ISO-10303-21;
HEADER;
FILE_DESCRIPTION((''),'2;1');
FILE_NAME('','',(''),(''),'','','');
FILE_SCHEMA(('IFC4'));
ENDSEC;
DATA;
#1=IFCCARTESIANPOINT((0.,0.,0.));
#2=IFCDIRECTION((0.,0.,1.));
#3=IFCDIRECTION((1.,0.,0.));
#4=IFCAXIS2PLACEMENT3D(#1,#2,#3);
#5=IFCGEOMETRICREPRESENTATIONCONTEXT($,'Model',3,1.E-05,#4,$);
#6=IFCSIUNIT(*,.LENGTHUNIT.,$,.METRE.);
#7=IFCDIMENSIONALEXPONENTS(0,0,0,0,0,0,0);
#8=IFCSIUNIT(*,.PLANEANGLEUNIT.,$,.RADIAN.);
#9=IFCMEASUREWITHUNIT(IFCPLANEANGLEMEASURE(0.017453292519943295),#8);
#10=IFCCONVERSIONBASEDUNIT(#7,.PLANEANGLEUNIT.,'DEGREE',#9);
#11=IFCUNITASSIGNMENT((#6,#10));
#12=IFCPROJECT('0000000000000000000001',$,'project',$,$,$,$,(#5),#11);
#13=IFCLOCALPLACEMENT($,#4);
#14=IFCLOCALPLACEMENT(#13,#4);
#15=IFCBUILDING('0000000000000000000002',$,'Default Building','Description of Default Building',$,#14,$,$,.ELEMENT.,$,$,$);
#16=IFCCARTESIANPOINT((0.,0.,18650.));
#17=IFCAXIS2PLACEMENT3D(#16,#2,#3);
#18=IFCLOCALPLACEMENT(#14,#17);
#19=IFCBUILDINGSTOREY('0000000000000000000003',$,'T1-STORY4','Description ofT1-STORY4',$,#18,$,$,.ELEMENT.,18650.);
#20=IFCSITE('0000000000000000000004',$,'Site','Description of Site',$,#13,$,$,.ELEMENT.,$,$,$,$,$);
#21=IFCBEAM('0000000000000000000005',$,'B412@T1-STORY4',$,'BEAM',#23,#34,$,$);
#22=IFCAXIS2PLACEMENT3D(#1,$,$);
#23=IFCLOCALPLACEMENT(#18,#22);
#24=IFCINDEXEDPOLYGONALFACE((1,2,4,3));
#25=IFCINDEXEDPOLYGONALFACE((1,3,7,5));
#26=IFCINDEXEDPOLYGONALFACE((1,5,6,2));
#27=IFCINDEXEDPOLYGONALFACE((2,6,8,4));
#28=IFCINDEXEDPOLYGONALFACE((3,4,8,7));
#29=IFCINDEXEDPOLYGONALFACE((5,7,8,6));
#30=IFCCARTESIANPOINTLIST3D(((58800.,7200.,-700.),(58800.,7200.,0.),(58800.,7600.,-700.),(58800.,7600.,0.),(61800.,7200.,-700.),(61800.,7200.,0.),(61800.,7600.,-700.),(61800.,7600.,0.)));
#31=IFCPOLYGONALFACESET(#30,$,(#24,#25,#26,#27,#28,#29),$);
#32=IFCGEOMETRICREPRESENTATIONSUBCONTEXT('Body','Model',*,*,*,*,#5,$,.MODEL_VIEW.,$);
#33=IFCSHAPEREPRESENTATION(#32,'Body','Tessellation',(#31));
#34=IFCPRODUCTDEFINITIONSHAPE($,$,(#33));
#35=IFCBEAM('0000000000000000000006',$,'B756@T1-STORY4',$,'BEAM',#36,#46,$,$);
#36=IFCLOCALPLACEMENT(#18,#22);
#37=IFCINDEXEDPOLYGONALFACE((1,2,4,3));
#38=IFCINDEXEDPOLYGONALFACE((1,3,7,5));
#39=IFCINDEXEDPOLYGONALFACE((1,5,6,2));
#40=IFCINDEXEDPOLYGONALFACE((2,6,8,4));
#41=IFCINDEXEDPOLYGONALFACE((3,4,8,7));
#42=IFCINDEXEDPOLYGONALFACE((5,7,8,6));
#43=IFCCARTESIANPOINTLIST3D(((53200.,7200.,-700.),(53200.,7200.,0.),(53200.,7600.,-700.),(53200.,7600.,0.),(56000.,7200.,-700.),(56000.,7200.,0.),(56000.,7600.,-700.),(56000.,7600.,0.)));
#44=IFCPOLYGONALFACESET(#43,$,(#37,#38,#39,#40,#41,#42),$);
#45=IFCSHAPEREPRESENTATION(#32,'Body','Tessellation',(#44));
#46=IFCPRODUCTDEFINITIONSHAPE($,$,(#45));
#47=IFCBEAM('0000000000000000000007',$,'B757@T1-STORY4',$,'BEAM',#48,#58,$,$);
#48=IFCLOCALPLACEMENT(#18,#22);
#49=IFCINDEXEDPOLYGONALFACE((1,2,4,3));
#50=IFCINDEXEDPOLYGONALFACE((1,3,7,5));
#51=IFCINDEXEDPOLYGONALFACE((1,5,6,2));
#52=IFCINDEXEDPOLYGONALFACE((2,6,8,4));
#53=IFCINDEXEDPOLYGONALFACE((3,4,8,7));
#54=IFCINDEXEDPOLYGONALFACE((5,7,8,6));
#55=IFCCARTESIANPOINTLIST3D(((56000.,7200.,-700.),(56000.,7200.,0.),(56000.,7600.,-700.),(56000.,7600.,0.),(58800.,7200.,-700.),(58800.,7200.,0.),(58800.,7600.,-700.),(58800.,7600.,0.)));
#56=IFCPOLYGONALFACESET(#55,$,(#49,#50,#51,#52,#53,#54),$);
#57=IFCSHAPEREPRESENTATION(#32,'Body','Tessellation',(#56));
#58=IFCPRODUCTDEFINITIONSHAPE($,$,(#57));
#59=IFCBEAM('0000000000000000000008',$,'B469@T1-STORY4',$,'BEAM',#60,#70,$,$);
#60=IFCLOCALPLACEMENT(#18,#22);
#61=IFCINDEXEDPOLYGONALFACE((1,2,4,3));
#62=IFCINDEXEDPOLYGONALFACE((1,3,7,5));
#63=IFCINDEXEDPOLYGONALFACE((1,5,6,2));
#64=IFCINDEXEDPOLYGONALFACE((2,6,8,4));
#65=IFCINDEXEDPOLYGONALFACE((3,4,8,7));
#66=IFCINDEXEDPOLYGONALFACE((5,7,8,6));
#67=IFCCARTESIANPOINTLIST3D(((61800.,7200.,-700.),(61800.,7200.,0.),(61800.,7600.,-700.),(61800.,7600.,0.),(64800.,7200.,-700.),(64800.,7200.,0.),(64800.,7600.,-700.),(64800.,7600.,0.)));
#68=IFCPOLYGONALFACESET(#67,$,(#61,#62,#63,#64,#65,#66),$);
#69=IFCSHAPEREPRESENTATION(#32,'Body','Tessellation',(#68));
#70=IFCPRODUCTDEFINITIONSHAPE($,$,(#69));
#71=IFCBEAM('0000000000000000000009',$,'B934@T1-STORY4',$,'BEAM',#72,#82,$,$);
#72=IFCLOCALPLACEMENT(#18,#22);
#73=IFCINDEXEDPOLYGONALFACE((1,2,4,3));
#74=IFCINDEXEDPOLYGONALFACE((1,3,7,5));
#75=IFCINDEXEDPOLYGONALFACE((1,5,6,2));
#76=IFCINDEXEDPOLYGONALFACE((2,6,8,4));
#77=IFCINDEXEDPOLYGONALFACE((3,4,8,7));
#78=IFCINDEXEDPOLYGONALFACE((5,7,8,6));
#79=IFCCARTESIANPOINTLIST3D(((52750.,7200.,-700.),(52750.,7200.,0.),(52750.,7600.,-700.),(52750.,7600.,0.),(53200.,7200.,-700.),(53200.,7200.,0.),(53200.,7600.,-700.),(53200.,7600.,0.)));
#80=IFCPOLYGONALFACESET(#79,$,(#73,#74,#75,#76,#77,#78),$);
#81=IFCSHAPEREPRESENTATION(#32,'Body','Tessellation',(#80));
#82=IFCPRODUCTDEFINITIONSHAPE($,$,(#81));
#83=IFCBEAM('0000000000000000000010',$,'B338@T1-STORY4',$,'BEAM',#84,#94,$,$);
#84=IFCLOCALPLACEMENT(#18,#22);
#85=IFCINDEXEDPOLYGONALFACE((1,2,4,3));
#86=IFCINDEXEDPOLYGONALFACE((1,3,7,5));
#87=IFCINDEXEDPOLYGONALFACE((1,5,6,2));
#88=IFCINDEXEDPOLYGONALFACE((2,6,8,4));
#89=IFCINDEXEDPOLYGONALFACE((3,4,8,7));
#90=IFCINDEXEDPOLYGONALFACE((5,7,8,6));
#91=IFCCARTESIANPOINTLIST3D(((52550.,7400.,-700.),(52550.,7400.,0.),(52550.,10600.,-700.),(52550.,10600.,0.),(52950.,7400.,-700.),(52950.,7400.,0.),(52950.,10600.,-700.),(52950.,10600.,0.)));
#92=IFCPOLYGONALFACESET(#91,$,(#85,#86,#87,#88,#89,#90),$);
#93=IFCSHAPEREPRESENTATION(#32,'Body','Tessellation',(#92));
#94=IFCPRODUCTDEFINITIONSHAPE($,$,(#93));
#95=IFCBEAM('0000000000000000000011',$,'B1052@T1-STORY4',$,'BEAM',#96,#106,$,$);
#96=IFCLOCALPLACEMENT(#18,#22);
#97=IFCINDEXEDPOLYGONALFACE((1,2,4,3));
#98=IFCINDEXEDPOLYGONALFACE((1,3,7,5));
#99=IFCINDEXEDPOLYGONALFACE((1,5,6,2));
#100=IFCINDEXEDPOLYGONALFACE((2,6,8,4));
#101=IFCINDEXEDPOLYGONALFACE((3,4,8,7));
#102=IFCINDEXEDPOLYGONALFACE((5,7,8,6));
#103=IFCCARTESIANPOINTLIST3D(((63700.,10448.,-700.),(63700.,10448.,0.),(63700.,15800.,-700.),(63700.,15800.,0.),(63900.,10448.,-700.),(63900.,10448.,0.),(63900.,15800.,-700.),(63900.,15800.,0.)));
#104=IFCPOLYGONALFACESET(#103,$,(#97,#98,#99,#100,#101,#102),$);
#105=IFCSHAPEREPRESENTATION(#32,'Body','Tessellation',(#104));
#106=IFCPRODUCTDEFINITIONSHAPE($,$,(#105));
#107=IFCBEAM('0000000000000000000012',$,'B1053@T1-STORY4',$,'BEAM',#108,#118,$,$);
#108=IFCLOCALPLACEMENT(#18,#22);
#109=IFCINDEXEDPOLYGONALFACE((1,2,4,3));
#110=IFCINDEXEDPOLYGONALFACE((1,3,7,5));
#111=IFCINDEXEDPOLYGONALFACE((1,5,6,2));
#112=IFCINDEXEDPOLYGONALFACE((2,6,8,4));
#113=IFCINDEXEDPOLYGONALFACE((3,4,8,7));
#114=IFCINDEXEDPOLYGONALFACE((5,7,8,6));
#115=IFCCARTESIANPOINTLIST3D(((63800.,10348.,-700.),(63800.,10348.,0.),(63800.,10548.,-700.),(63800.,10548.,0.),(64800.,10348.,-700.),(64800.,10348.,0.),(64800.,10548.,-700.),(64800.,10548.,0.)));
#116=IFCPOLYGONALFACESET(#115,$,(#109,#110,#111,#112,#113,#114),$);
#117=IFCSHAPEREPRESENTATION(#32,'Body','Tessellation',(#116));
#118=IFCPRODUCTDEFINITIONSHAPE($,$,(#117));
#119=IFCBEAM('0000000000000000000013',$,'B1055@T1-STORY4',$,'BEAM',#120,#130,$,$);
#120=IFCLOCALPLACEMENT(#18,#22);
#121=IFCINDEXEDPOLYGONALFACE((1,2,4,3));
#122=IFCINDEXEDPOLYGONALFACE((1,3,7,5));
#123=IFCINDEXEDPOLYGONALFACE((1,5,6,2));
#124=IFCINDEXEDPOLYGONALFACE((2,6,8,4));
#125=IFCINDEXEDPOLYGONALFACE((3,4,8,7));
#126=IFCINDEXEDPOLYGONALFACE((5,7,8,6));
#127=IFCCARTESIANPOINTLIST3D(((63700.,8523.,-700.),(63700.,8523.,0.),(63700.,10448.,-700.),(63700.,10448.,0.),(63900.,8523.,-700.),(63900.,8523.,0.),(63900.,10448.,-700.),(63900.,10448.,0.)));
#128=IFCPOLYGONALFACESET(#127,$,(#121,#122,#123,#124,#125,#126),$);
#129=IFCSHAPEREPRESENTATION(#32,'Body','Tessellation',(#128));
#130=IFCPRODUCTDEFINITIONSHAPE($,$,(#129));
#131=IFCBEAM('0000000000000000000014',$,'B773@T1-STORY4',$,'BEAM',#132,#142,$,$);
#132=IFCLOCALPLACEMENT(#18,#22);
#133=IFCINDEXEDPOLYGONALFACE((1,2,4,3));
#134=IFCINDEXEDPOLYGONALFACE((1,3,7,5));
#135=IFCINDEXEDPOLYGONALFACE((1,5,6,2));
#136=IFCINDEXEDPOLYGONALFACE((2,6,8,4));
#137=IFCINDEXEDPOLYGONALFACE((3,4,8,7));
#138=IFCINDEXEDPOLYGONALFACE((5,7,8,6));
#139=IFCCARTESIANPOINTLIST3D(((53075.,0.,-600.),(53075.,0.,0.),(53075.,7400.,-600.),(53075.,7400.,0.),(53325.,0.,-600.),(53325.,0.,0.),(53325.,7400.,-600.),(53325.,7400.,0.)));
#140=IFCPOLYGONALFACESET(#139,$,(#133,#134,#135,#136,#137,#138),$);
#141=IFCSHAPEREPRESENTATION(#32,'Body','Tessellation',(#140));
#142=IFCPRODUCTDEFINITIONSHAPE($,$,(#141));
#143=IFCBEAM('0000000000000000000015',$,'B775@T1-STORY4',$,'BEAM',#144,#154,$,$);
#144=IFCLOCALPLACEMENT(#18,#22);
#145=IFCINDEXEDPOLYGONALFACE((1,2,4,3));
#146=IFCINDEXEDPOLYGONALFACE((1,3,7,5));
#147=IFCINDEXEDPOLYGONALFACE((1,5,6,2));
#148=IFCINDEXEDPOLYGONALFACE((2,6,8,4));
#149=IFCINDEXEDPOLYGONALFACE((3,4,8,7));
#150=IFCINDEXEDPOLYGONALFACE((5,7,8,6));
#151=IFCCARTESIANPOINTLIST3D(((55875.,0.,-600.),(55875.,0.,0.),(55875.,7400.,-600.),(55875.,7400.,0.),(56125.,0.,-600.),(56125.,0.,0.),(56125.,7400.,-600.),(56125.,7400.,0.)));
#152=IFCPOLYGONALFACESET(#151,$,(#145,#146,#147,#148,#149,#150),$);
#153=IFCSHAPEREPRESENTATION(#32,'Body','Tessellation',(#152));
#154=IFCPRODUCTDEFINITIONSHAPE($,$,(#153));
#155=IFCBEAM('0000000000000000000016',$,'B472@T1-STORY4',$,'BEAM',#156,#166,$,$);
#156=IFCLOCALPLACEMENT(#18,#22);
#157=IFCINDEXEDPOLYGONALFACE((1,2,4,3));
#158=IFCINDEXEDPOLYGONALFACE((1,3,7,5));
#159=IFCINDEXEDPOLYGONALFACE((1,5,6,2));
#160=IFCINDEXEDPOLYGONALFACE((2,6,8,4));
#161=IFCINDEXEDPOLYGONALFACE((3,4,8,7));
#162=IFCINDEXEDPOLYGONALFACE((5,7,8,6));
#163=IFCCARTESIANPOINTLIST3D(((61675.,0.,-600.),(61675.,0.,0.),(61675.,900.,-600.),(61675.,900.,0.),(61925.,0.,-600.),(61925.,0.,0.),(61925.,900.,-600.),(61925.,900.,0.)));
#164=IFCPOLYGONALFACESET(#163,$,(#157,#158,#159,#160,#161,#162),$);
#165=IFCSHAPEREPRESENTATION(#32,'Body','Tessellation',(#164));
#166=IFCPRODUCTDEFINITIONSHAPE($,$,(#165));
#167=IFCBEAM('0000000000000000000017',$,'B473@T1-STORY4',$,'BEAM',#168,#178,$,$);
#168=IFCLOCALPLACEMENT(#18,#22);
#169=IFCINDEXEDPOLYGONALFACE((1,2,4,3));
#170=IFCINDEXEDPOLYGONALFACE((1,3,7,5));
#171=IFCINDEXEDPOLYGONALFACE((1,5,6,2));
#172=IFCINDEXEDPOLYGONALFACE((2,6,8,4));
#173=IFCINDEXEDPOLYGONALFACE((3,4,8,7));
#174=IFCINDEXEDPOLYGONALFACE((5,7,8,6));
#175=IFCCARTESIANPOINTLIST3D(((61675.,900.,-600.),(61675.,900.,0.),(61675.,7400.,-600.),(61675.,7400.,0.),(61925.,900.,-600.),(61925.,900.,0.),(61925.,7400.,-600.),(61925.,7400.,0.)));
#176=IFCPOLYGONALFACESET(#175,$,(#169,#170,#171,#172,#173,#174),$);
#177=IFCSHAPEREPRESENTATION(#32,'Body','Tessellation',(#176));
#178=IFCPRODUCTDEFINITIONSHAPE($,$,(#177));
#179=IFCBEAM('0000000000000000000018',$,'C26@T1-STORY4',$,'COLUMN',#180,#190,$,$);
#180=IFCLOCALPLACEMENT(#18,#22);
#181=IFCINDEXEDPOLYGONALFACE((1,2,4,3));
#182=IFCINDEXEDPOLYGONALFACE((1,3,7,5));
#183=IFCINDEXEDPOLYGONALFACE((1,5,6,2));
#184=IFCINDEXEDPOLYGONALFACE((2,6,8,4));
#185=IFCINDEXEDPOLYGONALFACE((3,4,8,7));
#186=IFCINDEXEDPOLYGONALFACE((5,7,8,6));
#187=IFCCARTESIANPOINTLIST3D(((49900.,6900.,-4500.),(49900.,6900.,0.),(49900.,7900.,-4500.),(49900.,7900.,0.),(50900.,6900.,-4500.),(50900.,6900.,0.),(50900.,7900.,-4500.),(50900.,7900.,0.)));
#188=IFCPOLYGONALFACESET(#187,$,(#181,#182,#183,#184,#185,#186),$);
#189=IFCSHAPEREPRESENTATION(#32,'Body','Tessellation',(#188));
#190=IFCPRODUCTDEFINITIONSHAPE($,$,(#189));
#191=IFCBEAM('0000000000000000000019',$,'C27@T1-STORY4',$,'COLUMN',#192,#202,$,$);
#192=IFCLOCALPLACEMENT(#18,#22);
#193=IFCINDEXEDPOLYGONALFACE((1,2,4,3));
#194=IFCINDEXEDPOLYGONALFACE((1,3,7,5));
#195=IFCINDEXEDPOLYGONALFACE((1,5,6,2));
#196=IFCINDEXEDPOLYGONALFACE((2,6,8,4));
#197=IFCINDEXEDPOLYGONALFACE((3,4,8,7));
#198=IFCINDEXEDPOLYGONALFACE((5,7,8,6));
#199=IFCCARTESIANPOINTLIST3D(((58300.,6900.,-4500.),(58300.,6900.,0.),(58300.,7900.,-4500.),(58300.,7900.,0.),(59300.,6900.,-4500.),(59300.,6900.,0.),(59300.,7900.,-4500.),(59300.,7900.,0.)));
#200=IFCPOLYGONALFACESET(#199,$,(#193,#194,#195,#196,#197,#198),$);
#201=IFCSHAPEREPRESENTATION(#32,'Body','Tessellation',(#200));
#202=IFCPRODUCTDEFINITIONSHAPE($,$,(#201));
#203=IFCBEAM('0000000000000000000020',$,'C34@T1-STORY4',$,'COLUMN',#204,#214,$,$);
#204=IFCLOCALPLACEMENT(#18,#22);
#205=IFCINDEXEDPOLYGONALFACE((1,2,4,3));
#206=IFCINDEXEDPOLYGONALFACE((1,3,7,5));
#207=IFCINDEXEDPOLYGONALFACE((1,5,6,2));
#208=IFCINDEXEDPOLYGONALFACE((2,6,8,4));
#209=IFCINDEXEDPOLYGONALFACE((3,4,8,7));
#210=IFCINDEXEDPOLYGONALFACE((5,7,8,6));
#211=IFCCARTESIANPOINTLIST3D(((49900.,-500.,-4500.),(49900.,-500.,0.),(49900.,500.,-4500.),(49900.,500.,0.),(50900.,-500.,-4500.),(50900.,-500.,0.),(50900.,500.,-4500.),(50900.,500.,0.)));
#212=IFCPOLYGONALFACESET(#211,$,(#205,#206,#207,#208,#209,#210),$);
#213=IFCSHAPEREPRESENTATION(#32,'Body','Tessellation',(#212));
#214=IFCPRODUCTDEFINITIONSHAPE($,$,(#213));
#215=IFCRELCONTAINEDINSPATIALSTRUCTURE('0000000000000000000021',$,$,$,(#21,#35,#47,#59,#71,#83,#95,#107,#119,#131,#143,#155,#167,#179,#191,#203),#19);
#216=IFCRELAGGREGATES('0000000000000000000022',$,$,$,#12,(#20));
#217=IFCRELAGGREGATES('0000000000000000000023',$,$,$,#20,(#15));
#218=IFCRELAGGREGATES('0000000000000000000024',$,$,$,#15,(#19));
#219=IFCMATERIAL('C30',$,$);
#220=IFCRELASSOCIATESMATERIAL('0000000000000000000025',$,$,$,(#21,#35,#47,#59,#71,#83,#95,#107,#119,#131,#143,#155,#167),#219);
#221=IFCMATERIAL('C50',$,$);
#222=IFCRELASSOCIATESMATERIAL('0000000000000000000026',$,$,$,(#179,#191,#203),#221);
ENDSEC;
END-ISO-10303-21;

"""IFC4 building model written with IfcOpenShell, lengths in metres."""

from ifc_helpers import new_model, entity, si_unit, converted_unit, frame, origin_with_axes, place, context, subcontext, project, spatial, rectangle, extrude, material, element, save


model = new_model("IFC4")

# Units and contexts
model_context = context("Model", 3, precision=1e-05, world=origin_with_axes())
body_context = subcontext(model_context, "Body", "Model", "MODEL_VIEW")
ifc_project = project(units=[si_unit("LENGTHUNIT", "METRE"), converted_unit("PLANEANGLEUNIT", "DEGREE", entity("IfcPlaneAngleMeasure", 0.017453292519943295), si_unit("PLANEANGLEUNIT", "RADIAN"), dimensions=[0, 0, 0, 0, 0, 0, 0])], contexts=[model_context])

# Site, building, storey
site_placement = place(None, origin_with_axes())
site = spatial("IfcSite", under=ifc_project, at=site_placement, Name="Site", Description="Description of Site", CompositionType="ELEMENT")
building_placement = place(site_placement, origin_with_axes())
building = spatial("IfcBuilding", under=site, at=building_placement, Name="Default Building", Description="Description of Default Building", CompositionType="ELEMENT")
storey_placement = place(building_placement, frame((0.0, 0.0, 18650.0), z_axis=(0.0, 0.0, 1.0), x_axis=(1.0, 0.0, 0.0)))
storey = spatial("IfcBuildingStorey", under=building, at=storey_placement, Name="T1-STORY4", Description="Description ofT1-STORY4", CompositionType="ELEMENT", Elevation=18650.0)

# Beams
ifc_material_1 = material(Name="C30")
beam_1_placement = place(storey_placement, frame((58800.0, 7400.0, -350.0), z_axis=(1.0, 0.0, 0.0), x_axis=(0.0, 1.0, 0.0)))
element("IfcBeam", 1, at=beam_1_placement, inside=storey, material=ifc_material_1, Name="B412@T1-STORY4", ObjectType="BEAM", context=body_context, shape_type="SweptSolid", body=[
    extrude(rectangle(XDim=400.0, YDim=700.0), origin_with_axes(), (0.0, 0.0, 1.0), 3000.0),
])
for number, where, z_axis, x_axis, name in (
    (2, (53200.0, 7400.0, -350.0), (1.0, 0.0, 0.0), (0.0, 1.0, 0.0), "B756@T1-STORY4"),
    (3, (56000.0, 7400.0, -350.0), (1.0, 0.0, 0.0), (0.0, 1.0, 0.0), "B757@T1-STORY4"),
):
    element("IfcBeam", number, at=place(storey_placement, frame(where, z_axis=z_axis, x_axis=x_axis)), inside=storey, material=ifc_material_1, Name=name, ObjectType="BEAM", context=body_context, shape_type="SweptSolid", body=[
        extrude(rectangle(XDim=400.0, YDim=700.0), origin_with_axes(), (0.0, 0.0, 1.0), 2800.0),
    ])
beam_2_placement = place(storey_placement, frame((61800.0, 7400.0, -350.0), z_axis=(1.0, 0.0, 0.0), x_axis=(0.0, 1.0, 0.0)))
element("IfcBeam", 4, at=beam_2_placement, inside=storey, material=ifc_material_1, Name="B469@T1-STORY4", ObjectType="BEAM", context=body_context, shape_type="SweptSolid", body=[
    extrude(rectangle(XDim=400.0, YDim=700.0), origin_with_axes(), (0.0, 0.0, 1.0), 3000.0),
])
beam_3_placement = place(storey_placement, frame((52750.0, 7400.0, -350.0), z_axis=(1.0, 0.0, 0.0), x_axis=(0.0, 1.0, 0.0)))
element("IfcBeam", 5, at=beam_3_placement, inside=storey, material=ifc_material_1, Name="B934@T1-STORY4", ObjectType="BEAM", context=body_context, shape_type="SweptSolid", body=[
    extrude(rectangle(XDim=400.0, YDim=700.0), origin_with_axes(), (0.0, 0.0, 1.0), 450.0),
])
beam_4_placement = place(storey_placement, frame((52750.0, 7400.0, -350.0), z_axis=(0.0, 1.0, 0.0), x_axis=(-1.0, 0.0, 0.0)))
element("IfcBeam", 6, at=beam_4_placement, inside=storey, material=ifc_material_1, Name="B338@T1-STORY4", ObjectType="BEAM", context=body_context, shape_type="SweptSolid", body=[
    extrude(rectangle(XDim=400.0, YDim=700.0), origin_with_axes(), (0.0, 0.0, 1.0), 3200.0),
])
beam_5_placement = place(storey_placement, frame((63800.0, 10448.0, -350.0), z_axis=(0.0, 1.0, 0.0), x_axis=(-1.0, 0.0, 0.0)))
element("IfcBeam", 7, at=beam_5_placement, inside=storey, material=ifc_material_1, Name="B1052@T1-STORY4", ObjectType="BEAM", context=body_context, shape_type="SweptSolid", body=[
    extrude(rectangle(XDim=200.0, YDim=700.0), origin_with_axes(), (0.0, 0.0, 1.0), 5352.0),
])
beam_6_placement = place(storey_placement, frame((63800.0, 10448.0, -350.0), z_axis=(1.0, 0.0, 0.0), x_axis=(0.0, 1.0, 0.0)))
element("IfcBeam", 8, at=beam_6_placement, inside=storey, material=ifc_material_1, Name="B1053@T1-STORY4", ObjectType="BEAM", context=body_context, shape_type="SweptSolid", body=[
    extrude(rectangle(XDim=200.0, YDim=700.0), origin_with_axes(), (0.0, 0.0, 1.0), 1000.0),
])
beam_7_placement = place(storey_placement, frame((63800.0, 8523.0, -350.0), z_axis=(0.0, 1.0, 0.0), x_axis=(-1.0, 0.0, 0.0)))
element("IfcBeam", 9, at=beam_7_placement, inside=storey, material=ifc_material_1, Name="B1055@T1-STORY4", ObjectType="BEAM", context=body_context, shape_type="SweptSolid", body=[
    extrude(rectangle(XDim=200.0, YDim=700.0), origin_with_axes(), (0.0, 0.0, 1.0), 1925.0),
])
for number, where, z_axis, x_axis, name in (
    (10, (53200.0, 0.0, -300.0), (0.0, 1.0, 0.0), (-1.0, 0.0, 0.0), "B773@T1-STORY4"),
    (11, (56000.0, 0.0, -300.0), (0.0, 1.0, 0.0), (-1.0, 0.0, 0.0), "B775@T1-STORY4"),
):
    element("IfcBeam", number, at=place(storey_placement, frame(where, z_axis=z_axis, x_axis=x_axis)), inside=storey, material=ifc_material_1, Name=name, ObjectType="BEAM", context=body_context, shape_type="SweptSolid", body=[
        extrude(rectangle(XDim=250.0, YDim=600.0), origin_with_axes(), (0.0, 0.0, 1.0), 7400.0),
    ])
beam_8_placement = place(storey_placement, frame((61800.0, 0.0, -300.0), z_axis=(0.0, 1.0, 0.0), x_axis=(-1.0, 0.0, 0.0)))
element("IfcBeam", 12, at=beam_8_placement, inside=storey, material=ifc_material_1, Name="B472@T1-STORY4", ObjectType="BEAM", context=body_context, shape_type="SweptSolid", body=[
    extrude(rectangle(XDim=250.0, YDim=600.0), origin_with_axes(), (0.0, 0.0, 1.0), 900.0),
])
beam_9_placement = place(storey_placement, frame((61800.0, 900.0, -300.0), z_axis=(0.0, 1.0, 0.0), x_axis=(-1.0, 0.0, 0.0)))
element("IfcBeam", 13, at=beam_9_placement, inside=storey, material=ifc_material_1, Name="B473@T1-STORY4", ObjectType="BEAM", context=body_context, shape_type="SweptSolid", body=[
    extrude(rectangle(XDim=250.0, YDim=600.0), origin_with_axes(), (0.0, 0.0, 1.0), 6500.0),
])
ifc_material_2 = material(Name="C50")
for number, where, z_axis, x_axis, name in (
    (14, (50400.0, 7400.0, -4500.0), (0.0, 0.0, 1.0), (-1.0, 0.0, 0.0), "C26@T1-STORY4"),
    (15, (58800.0, 7400.0, -4500.0), (0.0, 0.0, 1.0), (-1.0, 0.0, 0.0), "C27@T1-STORY4"),
    (16, (50400.0, 0.0, -4500.0), (0.0, 0.0, 1.0), (-1.0, 0.0, 0.0), "C34@T1-STORY4"),
):
    element("IfcBeam", number, at=place(storey_placement, frame(where, z_axis=z_axis, x_axis=x_axis)), inside=storey, material=ifc_material_2, Name=name, ObjectType="COLUMN", context=body_context, shape_type="SweptSolid", body=[
        extrude(rectangle(XDim=1000.0, YDim=1000.0), origin_with_axes(), (0.0, 0.0, 1.0), 4500.0),
    ])

save(model, "model.ifc")
